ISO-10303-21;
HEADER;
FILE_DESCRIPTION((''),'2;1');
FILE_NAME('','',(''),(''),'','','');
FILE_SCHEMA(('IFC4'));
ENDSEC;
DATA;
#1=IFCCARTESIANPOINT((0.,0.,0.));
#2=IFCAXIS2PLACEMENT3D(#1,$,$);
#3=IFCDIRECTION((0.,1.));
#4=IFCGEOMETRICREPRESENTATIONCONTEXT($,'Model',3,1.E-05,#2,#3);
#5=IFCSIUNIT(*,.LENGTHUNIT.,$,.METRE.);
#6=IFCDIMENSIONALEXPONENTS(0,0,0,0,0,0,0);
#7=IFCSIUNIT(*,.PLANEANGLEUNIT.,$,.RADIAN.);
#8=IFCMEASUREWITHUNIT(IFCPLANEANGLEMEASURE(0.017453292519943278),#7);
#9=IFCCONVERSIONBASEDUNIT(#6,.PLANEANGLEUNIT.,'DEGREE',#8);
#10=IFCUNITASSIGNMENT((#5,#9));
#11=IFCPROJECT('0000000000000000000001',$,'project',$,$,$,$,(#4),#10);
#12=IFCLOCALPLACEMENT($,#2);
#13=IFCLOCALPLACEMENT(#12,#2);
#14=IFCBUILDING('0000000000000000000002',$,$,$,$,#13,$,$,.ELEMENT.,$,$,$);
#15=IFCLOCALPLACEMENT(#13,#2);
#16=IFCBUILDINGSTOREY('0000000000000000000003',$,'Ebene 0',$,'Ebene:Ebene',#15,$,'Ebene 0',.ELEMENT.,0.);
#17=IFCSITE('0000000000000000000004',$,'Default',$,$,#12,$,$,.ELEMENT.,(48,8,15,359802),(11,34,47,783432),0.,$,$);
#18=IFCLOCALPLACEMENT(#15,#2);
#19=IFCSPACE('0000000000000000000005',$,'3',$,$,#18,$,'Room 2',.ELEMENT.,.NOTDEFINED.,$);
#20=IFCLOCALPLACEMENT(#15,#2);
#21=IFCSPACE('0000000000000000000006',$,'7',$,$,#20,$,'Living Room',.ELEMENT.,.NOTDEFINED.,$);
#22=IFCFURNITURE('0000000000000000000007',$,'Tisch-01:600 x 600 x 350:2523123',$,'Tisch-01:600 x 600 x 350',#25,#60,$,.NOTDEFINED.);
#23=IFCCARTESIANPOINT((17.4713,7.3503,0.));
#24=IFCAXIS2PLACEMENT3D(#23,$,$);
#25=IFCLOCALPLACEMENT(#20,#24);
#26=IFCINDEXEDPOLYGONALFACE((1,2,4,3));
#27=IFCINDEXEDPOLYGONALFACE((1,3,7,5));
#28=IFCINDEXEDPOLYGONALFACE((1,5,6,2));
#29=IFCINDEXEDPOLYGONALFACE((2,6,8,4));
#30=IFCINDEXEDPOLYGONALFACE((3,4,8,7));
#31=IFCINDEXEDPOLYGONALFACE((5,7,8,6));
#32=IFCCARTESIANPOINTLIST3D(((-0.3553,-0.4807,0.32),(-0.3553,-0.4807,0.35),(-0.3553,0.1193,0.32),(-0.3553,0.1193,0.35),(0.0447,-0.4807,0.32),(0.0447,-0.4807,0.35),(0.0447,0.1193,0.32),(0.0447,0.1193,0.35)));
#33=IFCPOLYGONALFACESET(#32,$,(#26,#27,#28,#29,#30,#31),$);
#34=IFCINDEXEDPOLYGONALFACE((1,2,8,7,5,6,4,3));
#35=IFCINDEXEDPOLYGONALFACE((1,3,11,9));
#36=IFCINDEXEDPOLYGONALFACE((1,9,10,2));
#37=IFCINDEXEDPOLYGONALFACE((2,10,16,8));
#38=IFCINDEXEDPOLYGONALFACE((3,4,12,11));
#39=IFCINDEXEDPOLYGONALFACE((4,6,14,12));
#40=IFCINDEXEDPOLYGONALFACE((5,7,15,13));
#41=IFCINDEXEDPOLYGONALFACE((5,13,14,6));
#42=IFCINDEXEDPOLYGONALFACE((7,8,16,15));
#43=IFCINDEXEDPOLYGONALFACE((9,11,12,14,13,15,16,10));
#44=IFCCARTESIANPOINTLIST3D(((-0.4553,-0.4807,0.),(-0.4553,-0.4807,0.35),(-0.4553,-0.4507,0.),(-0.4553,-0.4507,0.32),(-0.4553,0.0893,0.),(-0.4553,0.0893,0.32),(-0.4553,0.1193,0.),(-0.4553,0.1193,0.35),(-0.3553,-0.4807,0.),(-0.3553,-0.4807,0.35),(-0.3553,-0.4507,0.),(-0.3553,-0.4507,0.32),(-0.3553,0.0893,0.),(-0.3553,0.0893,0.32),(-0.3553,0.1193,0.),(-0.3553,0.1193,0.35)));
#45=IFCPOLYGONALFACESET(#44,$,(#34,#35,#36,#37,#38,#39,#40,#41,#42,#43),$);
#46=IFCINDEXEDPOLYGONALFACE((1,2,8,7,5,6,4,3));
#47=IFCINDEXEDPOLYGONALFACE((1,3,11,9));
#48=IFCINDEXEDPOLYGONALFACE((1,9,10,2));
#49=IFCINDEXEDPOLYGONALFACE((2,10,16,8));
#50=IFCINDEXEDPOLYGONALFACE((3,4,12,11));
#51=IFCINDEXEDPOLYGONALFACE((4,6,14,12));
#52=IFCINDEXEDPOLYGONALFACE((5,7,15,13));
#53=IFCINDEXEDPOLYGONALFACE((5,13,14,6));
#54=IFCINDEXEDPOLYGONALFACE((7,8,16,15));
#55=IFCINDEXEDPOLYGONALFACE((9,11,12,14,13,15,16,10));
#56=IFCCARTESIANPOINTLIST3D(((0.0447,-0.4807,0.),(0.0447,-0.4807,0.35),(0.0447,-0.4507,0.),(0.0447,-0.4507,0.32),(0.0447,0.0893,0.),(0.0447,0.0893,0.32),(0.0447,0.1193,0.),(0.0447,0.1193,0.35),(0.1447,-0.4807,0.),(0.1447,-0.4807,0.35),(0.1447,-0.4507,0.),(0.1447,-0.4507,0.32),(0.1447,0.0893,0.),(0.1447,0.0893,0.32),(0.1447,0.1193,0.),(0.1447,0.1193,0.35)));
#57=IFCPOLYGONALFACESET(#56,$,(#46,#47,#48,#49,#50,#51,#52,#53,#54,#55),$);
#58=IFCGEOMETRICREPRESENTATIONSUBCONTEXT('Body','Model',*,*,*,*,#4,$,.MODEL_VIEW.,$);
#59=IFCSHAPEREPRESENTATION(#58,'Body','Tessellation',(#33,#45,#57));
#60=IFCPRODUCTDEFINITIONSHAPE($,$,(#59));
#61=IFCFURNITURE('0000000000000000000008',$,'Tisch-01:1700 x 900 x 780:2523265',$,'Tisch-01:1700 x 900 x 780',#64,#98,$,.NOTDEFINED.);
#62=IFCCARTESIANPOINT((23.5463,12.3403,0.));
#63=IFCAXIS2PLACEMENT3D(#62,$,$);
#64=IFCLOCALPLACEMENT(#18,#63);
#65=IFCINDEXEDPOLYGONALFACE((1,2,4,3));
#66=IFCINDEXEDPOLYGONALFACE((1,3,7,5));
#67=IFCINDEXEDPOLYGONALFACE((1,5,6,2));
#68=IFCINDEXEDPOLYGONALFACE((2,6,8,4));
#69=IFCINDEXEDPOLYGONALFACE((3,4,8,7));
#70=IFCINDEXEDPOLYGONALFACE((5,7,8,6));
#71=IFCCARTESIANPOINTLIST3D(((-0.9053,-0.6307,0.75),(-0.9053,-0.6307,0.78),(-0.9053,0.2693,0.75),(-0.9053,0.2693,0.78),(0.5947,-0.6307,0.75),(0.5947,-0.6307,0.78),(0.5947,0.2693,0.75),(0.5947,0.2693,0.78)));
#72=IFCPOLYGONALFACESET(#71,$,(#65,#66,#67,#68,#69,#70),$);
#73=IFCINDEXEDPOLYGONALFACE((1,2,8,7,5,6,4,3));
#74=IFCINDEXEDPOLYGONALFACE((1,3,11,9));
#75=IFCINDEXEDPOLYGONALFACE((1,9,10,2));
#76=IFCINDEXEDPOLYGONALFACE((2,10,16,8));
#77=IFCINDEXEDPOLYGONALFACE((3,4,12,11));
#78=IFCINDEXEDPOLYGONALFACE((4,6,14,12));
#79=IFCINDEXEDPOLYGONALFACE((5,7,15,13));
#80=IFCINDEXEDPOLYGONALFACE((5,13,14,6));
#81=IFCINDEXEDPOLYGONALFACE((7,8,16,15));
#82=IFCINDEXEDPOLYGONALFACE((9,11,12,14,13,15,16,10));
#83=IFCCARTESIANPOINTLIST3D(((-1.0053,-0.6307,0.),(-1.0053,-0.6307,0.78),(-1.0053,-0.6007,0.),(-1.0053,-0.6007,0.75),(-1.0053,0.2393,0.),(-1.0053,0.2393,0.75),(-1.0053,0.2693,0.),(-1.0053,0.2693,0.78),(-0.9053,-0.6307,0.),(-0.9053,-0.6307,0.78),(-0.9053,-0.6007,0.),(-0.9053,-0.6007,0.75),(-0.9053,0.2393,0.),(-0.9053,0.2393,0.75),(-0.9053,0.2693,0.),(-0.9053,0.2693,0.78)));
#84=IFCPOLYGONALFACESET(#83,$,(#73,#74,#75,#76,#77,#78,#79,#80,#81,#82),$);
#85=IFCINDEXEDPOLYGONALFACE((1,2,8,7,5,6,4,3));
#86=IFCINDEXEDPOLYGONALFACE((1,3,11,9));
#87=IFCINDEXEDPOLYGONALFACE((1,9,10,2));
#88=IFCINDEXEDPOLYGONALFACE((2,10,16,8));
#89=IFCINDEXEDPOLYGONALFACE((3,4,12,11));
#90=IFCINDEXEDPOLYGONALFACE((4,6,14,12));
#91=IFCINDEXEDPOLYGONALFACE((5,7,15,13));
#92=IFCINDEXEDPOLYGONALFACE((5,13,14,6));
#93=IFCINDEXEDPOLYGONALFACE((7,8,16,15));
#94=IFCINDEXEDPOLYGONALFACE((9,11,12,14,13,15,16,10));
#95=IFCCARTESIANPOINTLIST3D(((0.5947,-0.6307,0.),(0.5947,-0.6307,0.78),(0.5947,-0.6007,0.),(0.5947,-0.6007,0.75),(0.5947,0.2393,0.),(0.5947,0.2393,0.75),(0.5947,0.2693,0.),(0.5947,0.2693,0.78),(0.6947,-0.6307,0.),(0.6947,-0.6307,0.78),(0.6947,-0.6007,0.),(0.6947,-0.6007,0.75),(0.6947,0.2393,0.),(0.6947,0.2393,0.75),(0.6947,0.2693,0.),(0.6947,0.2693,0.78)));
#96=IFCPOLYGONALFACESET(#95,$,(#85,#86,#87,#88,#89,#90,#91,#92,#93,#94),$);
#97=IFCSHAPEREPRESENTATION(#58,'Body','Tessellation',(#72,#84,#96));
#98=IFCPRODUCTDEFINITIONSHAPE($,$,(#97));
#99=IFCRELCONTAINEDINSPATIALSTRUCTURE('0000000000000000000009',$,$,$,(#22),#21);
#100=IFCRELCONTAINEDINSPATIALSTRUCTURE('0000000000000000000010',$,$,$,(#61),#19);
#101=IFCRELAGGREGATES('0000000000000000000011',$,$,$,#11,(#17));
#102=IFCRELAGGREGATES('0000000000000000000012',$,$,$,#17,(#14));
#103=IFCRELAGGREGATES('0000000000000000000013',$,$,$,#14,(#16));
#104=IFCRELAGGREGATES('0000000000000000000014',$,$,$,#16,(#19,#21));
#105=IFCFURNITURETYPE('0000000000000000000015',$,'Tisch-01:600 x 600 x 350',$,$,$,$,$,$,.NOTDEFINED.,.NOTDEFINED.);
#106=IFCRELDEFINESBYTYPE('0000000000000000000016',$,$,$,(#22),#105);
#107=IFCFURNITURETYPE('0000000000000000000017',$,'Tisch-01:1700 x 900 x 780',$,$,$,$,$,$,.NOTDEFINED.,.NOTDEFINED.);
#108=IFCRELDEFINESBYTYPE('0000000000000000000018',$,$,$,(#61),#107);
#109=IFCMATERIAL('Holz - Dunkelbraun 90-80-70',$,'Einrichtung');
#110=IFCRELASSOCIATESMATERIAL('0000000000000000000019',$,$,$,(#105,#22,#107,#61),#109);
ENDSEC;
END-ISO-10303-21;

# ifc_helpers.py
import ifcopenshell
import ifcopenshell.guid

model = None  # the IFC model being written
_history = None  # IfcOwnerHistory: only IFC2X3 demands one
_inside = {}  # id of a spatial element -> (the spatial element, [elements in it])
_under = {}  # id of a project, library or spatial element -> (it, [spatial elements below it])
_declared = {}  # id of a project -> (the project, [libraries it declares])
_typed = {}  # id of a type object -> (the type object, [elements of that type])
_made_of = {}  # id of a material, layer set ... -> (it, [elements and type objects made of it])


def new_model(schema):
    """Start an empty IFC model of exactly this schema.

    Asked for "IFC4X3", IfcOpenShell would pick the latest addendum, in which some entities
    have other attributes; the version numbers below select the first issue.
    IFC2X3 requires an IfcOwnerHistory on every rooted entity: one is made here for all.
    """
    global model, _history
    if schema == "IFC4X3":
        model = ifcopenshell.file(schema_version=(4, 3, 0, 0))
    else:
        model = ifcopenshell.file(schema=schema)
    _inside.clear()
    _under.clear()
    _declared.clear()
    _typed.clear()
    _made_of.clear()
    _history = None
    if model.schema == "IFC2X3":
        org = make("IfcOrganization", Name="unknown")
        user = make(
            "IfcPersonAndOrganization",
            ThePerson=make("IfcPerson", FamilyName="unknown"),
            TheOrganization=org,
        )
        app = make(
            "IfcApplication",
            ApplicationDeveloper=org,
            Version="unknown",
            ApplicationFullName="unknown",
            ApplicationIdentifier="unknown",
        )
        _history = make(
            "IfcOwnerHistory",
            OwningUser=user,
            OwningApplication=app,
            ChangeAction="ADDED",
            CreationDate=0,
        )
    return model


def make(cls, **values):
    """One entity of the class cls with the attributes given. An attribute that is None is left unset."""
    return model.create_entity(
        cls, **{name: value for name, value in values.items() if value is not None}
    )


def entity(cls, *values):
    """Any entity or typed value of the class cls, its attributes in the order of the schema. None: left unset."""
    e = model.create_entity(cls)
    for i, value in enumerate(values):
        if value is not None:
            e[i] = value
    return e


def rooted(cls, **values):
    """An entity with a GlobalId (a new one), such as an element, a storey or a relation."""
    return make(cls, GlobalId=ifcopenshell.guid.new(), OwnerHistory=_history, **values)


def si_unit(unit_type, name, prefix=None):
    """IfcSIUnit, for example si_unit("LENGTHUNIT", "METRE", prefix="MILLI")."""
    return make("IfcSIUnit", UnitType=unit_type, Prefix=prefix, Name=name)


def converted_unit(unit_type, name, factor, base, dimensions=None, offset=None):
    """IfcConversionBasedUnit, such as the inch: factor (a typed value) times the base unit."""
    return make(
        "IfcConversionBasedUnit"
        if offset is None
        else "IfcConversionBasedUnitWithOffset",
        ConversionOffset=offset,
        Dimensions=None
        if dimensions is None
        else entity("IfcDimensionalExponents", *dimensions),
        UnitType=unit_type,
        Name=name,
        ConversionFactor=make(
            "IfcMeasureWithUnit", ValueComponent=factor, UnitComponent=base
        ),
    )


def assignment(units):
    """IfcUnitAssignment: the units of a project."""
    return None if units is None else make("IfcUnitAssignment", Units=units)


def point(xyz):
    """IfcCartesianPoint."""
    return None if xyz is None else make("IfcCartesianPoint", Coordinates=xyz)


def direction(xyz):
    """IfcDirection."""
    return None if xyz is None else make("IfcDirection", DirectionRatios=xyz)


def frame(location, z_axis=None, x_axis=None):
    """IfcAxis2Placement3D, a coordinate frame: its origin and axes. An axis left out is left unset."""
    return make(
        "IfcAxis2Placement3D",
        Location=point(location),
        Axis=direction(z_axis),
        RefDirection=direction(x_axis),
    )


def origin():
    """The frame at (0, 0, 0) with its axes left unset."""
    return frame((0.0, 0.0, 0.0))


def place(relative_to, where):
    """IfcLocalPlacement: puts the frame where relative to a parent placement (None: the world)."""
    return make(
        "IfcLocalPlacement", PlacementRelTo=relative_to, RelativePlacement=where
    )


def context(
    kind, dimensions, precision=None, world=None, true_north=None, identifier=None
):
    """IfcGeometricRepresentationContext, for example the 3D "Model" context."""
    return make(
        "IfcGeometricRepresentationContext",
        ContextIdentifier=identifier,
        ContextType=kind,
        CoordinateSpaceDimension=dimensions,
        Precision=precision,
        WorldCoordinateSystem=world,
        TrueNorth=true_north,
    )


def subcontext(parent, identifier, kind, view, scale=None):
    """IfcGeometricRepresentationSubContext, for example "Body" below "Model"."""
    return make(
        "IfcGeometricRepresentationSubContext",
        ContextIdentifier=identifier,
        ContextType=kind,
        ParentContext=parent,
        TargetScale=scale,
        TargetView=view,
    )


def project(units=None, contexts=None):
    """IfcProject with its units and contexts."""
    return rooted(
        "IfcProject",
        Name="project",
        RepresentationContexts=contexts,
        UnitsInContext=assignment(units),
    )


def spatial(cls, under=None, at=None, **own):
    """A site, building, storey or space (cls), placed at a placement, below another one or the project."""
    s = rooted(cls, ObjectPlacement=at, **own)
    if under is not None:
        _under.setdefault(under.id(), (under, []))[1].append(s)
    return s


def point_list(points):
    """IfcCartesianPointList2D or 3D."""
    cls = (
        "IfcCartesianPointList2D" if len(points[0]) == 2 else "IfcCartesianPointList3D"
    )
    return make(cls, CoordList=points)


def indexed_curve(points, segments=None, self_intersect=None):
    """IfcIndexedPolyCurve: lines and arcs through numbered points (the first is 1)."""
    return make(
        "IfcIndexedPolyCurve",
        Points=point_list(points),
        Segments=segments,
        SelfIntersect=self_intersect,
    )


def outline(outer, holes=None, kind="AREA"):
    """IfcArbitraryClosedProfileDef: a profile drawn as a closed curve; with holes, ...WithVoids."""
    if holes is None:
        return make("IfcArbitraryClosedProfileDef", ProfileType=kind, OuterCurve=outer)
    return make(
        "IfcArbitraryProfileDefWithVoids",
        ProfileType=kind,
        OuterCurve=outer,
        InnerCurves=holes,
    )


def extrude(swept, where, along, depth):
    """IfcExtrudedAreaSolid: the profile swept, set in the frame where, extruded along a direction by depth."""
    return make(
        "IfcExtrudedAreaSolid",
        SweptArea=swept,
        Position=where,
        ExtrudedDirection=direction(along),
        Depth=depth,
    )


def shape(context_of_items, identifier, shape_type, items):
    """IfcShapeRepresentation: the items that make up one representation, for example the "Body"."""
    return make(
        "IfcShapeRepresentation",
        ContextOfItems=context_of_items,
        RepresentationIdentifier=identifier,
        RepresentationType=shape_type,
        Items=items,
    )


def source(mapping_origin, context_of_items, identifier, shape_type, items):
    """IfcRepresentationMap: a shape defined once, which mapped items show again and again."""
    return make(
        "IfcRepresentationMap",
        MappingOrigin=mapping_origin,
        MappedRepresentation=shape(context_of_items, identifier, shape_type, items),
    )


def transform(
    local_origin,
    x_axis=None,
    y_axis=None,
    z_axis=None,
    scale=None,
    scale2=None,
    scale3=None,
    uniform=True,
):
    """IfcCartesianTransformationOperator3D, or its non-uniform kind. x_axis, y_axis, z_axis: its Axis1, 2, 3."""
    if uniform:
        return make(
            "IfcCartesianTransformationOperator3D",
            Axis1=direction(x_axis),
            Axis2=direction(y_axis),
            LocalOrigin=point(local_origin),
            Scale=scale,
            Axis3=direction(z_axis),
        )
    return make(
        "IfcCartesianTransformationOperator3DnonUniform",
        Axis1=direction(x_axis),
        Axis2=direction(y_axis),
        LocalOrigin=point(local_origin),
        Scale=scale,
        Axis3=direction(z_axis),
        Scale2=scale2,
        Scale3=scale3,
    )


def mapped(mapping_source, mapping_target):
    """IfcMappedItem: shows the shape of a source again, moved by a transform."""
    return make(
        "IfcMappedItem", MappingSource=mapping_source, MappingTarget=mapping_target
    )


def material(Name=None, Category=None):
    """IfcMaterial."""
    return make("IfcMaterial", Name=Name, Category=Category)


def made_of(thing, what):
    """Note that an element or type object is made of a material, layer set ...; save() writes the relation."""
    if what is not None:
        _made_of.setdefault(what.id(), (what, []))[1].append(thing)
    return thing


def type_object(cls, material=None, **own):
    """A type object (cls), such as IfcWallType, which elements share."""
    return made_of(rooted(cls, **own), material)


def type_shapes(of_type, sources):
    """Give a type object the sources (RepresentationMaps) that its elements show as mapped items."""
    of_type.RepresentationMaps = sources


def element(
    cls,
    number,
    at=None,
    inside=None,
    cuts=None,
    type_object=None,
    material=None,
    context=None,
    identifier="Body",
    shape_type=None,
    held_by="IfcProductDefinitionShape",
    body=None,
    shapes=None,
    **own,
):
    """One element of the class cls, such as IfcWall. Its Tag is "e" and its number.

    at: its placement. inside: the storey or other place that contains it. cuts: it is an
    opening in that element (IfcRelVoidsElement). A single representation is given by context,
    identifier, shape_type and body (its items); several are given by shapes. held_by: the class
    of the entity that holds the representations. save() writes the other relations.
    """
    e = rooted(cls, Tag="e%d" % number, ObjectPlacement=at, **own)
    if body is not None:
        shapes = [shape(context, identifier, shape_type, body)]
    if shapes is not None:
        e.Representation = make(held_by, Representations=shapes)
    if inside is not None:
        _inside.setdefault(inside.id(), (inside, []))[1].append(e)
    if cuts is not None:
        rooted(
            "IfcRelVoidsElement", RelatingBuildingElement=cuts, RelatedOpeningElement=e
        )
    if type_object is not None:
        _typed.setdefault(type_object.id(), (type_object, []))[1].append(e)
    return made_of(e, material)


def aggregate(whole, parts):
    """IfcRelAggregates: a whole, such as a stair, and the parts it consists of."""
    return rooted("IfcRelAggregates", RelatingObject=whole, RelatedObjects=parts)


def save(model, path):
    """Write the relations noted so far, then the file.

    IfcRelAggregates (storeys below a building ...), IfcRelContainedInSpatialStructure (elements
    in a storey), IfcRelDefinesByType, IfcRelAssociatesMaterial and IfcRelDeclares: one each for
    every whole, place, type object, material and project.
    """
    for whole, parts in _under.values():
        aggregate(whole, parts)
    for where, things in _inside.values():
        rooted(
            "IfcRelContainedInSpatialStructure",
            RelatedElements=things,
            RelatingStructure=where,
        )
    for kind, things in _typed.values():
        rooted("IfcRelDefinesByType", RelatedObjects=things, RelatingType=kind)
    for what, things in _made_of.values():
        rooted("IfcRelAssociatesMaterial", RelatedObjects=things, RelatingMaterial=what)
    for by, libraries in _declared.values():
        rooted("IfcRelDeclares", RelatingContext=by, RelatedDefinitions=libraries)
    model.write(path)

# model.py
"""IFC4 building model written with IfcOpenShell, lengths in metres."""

from ifc_helpers import new_model, entity, si_unit, converted_unit, direction, frame, origin, place, context, subcontext, project, spatial, indexed_curve, outline, extrude, source, transform, mapped, material, type_object, type_shapes, element, save


model = new_model("IFC4")

# Units and contexts
model_context = context("Model", 3, precision=1e-05, world=origin(), true_north=direction((0.0, 1.0)))
body_context = subcontext(model_context, "Body", "Model", "MODEL_VIEW")
ifc_project = project(units=[si_unit("LENGTHUNIT", "METRE"), converted_unit("PLANEANGLEUNIT", "DEGREE", entity("IfcPlaneAngleMeasure", 0.017453292519943278), si_unit("PLANEANGLEUNIT", "RADIAN"), dimensions=[0, 0, 0, 0, 0, 0, 0])], contexts=[model_context])

# Site, building, storey
site_placement = place(None, origin())
site = spatial("IfcSite", under=ifc_project, at=site_placement, Name="Default", CompositionType="ELEMENT", RefLatitude=(48, 8, 15, 359802), RefLongitude=(11, 34, 47, 783432), RefElevation=0.0)
building_placement = place(site_placement, origin())
building = spatial("IfcBuilding", under=site, at=building_placement, CompositionType="ELEMENT")
storey_placement = place(building_placement, origin())
storey = spatial("IfcBuildingStorey", under=building, at=storey_placement, Name="Ebene 0", ObjectType="Ebene:Ebene", LongName="Ebene 0", CompositionType="ELEMENT", Elevation=0.0)

# Shared definitions
ifc_material_1 = material(Name="Holz - Dunkelbraun 90-80-70", Category="Einrichtung")

# Shared definitions
space_1_placement = place(storey_placement, origin())
space_1 = spatial("IfcSpace", under=storey, at=space_1_placement, Name="3", LongName="Room 2", CompositionType="ELEMENT", PredefinedType="NOTDEFINED")

# Shared definitions
space_2_placement = place(storey_placement, origin())
space_2 = spatial("IfcSpace", under=storey, at=space_2_placement, Name="7", LongName="Living Room", CompositionType="ELEMENT", PredefinedType="NOTDEFINED")

# Furniture
furniture_type_1 = type_object("IfcFurnitureType", Name="Tisch-01:600 x 600 x 350", AssemblyPlace="NOTDEFINED", PredefinedType="NOTDEFINED", material=ifc_material_1)
shared_shape_1 = source(origin(), body_context, "Body", "SweptSolid", [
    extrude(outline(indexed_curve([(-0.2, -0.3), (0.2, -0.3), (0.2, 0.3), (-0.2, 0.3), (-0.2, -0.3)], self_intersect=False)), frame((-0.1553, -0.1807, 0.32), z_axis=(0.0, 0.0, 1.0), x_axis=(-1.0, 0.0, 0.0)), (0.0, 0.0, 1.0), 0.03),
    extrude(outline(indexed_curve([(-0.1825, -0.3), (0.1675, -0.3), (0.1675, -0.27), (-0.1525, -0.27), (-0.1525, 0.27), (0.1675, 0.27), (0.1675, 0.3), (-0.1825, 0.3), (-0.1825, -0.3)], self_intersect=False)), frame((-0.4553, -0.1807, 0.1675), z_axis=(1.0, 0.0, 0.0), x_axis=(0.0, 0.0, -1.0)), (0.0, 0.0, 1.0), 0.1),
    extrude(outline(indexed_curve([(-0.1825, -0.3), (0.1675, -0.3), (0.1675, -0.27), (-0.1525, -0.27), (-0.1525, 0.27), (0.1675, 0.27), (0.1675, 0.3), (-0.1825, 0.3), (-0.1825, -0.3)], self_intersect=False)), frame((0.0447, -0.1807, 0.1675), z_axis=(1.0, 0.0, 0.0), x_axis=(0.0, 0.0, -1.0)), (0.0, 0.0, 1.0), 0.1),
])
type_shapes(furniture_type_1, [shared_shape_1])
furniture_1_placement = place(space_2_placement, frame((17.4713, 7.3503, 0.0)))
element("IfcFurniture", 1, at=furniture_1_placement, inside=space_2, type_object=furniture_type_1, material=ifc_material_1, Name="Tisch-01:600 x 600 x 350:2523123", ObjectType="Tisch-01:600 x 600 x 350", PredefinedType="NOTDEFINED", context=body_context, shape_type="MappedRepresentation", body=[
    mapped(shared_shape_1, transform((0.0, 0.0, 0.0), scale=1.0)),
])
furniture_type_2 = type_object("IfcFurnitureType", Name="Tisch-01:1700 x 900 x 780", AssemblyPlace="NOTDEFINED", PredefinedType="NOTDEFINED", material=ifc_material_1)
shared_shape_2 = source(origin(), body_context, "Body", "SweptSolid", [
    extrude(outline(indexed_curve([(-0.75, -0.45), (0.75, -0.45), (0.75, 0.45), (-0.75, 0.45), (-0.75, -0.45)], self_intersect=False)), frame((-0.1553, -0.1807, 0.75), z_axis=(0.0, 0.0, 1.0), x_axis=(-1.0, 0.0, 0.0)), (0.0, 0.0, 1.0), 0.03),
    extrude(outline(indexed_curve([(-0.3975, -0.45), (0.3825, -0.45), (0.3825, -0.42), (-0.3675, -0.42), (-0.3675, 0.42), (0.3825, 0.42), (0.3825, 0.45), (-0.3975, 0.45), (-0.3975, -0.45)], self_intersect=False)), frame((-1.0053, -0.1807, 0.3825), z_axis=(1.0, 0.0, 0.0), x_axis=(0.0, 0.0, -1.0)), (0.0, 0.0, 1.0), 0.1),
    extrude(outline(indexed_curve([(-0.3975, -0.45), (0.3825, -0.45), (0.3825, -0.42), (-0.3675, -0.42), (-0.3675, 0.42), (0.3825, 0.42), (0.3825, 0.45), (-0.3975, 0.45), (-0.3975, -0.45)], self_intersect=False)), frame((0.5947, -0.1807, 0.3825), z_axis=(1.0, 0.0, 0.0), x_axis=(0.0, 0.0, -1.0)), (0.0, 0.0, 1.0), 0.1),
])
type_shapes(furniture_type_2, [shared_shape_2])
furniture_2_placement = place(space_1_placement, frame((23.5463, 12.3403, 0.0)))
element("IfcFurniture", 2, at=furniture_2_placement, inside=space_1, type_object=furniture_type_2, material=ifc_material_1, Name="Tisch-01:1700 x 900 x 780:2523265", ObjectType="Tisch-01:1700 x 900 x 780", PredefinedType="NOTDEFINED", context=body_context, shape_type="MappedRepresentation", body=[
    mapped(shared_shape_2, transform((0.0, 0.0, 0.0), scale=1.0)),
])

save(model, "model.ifc")
